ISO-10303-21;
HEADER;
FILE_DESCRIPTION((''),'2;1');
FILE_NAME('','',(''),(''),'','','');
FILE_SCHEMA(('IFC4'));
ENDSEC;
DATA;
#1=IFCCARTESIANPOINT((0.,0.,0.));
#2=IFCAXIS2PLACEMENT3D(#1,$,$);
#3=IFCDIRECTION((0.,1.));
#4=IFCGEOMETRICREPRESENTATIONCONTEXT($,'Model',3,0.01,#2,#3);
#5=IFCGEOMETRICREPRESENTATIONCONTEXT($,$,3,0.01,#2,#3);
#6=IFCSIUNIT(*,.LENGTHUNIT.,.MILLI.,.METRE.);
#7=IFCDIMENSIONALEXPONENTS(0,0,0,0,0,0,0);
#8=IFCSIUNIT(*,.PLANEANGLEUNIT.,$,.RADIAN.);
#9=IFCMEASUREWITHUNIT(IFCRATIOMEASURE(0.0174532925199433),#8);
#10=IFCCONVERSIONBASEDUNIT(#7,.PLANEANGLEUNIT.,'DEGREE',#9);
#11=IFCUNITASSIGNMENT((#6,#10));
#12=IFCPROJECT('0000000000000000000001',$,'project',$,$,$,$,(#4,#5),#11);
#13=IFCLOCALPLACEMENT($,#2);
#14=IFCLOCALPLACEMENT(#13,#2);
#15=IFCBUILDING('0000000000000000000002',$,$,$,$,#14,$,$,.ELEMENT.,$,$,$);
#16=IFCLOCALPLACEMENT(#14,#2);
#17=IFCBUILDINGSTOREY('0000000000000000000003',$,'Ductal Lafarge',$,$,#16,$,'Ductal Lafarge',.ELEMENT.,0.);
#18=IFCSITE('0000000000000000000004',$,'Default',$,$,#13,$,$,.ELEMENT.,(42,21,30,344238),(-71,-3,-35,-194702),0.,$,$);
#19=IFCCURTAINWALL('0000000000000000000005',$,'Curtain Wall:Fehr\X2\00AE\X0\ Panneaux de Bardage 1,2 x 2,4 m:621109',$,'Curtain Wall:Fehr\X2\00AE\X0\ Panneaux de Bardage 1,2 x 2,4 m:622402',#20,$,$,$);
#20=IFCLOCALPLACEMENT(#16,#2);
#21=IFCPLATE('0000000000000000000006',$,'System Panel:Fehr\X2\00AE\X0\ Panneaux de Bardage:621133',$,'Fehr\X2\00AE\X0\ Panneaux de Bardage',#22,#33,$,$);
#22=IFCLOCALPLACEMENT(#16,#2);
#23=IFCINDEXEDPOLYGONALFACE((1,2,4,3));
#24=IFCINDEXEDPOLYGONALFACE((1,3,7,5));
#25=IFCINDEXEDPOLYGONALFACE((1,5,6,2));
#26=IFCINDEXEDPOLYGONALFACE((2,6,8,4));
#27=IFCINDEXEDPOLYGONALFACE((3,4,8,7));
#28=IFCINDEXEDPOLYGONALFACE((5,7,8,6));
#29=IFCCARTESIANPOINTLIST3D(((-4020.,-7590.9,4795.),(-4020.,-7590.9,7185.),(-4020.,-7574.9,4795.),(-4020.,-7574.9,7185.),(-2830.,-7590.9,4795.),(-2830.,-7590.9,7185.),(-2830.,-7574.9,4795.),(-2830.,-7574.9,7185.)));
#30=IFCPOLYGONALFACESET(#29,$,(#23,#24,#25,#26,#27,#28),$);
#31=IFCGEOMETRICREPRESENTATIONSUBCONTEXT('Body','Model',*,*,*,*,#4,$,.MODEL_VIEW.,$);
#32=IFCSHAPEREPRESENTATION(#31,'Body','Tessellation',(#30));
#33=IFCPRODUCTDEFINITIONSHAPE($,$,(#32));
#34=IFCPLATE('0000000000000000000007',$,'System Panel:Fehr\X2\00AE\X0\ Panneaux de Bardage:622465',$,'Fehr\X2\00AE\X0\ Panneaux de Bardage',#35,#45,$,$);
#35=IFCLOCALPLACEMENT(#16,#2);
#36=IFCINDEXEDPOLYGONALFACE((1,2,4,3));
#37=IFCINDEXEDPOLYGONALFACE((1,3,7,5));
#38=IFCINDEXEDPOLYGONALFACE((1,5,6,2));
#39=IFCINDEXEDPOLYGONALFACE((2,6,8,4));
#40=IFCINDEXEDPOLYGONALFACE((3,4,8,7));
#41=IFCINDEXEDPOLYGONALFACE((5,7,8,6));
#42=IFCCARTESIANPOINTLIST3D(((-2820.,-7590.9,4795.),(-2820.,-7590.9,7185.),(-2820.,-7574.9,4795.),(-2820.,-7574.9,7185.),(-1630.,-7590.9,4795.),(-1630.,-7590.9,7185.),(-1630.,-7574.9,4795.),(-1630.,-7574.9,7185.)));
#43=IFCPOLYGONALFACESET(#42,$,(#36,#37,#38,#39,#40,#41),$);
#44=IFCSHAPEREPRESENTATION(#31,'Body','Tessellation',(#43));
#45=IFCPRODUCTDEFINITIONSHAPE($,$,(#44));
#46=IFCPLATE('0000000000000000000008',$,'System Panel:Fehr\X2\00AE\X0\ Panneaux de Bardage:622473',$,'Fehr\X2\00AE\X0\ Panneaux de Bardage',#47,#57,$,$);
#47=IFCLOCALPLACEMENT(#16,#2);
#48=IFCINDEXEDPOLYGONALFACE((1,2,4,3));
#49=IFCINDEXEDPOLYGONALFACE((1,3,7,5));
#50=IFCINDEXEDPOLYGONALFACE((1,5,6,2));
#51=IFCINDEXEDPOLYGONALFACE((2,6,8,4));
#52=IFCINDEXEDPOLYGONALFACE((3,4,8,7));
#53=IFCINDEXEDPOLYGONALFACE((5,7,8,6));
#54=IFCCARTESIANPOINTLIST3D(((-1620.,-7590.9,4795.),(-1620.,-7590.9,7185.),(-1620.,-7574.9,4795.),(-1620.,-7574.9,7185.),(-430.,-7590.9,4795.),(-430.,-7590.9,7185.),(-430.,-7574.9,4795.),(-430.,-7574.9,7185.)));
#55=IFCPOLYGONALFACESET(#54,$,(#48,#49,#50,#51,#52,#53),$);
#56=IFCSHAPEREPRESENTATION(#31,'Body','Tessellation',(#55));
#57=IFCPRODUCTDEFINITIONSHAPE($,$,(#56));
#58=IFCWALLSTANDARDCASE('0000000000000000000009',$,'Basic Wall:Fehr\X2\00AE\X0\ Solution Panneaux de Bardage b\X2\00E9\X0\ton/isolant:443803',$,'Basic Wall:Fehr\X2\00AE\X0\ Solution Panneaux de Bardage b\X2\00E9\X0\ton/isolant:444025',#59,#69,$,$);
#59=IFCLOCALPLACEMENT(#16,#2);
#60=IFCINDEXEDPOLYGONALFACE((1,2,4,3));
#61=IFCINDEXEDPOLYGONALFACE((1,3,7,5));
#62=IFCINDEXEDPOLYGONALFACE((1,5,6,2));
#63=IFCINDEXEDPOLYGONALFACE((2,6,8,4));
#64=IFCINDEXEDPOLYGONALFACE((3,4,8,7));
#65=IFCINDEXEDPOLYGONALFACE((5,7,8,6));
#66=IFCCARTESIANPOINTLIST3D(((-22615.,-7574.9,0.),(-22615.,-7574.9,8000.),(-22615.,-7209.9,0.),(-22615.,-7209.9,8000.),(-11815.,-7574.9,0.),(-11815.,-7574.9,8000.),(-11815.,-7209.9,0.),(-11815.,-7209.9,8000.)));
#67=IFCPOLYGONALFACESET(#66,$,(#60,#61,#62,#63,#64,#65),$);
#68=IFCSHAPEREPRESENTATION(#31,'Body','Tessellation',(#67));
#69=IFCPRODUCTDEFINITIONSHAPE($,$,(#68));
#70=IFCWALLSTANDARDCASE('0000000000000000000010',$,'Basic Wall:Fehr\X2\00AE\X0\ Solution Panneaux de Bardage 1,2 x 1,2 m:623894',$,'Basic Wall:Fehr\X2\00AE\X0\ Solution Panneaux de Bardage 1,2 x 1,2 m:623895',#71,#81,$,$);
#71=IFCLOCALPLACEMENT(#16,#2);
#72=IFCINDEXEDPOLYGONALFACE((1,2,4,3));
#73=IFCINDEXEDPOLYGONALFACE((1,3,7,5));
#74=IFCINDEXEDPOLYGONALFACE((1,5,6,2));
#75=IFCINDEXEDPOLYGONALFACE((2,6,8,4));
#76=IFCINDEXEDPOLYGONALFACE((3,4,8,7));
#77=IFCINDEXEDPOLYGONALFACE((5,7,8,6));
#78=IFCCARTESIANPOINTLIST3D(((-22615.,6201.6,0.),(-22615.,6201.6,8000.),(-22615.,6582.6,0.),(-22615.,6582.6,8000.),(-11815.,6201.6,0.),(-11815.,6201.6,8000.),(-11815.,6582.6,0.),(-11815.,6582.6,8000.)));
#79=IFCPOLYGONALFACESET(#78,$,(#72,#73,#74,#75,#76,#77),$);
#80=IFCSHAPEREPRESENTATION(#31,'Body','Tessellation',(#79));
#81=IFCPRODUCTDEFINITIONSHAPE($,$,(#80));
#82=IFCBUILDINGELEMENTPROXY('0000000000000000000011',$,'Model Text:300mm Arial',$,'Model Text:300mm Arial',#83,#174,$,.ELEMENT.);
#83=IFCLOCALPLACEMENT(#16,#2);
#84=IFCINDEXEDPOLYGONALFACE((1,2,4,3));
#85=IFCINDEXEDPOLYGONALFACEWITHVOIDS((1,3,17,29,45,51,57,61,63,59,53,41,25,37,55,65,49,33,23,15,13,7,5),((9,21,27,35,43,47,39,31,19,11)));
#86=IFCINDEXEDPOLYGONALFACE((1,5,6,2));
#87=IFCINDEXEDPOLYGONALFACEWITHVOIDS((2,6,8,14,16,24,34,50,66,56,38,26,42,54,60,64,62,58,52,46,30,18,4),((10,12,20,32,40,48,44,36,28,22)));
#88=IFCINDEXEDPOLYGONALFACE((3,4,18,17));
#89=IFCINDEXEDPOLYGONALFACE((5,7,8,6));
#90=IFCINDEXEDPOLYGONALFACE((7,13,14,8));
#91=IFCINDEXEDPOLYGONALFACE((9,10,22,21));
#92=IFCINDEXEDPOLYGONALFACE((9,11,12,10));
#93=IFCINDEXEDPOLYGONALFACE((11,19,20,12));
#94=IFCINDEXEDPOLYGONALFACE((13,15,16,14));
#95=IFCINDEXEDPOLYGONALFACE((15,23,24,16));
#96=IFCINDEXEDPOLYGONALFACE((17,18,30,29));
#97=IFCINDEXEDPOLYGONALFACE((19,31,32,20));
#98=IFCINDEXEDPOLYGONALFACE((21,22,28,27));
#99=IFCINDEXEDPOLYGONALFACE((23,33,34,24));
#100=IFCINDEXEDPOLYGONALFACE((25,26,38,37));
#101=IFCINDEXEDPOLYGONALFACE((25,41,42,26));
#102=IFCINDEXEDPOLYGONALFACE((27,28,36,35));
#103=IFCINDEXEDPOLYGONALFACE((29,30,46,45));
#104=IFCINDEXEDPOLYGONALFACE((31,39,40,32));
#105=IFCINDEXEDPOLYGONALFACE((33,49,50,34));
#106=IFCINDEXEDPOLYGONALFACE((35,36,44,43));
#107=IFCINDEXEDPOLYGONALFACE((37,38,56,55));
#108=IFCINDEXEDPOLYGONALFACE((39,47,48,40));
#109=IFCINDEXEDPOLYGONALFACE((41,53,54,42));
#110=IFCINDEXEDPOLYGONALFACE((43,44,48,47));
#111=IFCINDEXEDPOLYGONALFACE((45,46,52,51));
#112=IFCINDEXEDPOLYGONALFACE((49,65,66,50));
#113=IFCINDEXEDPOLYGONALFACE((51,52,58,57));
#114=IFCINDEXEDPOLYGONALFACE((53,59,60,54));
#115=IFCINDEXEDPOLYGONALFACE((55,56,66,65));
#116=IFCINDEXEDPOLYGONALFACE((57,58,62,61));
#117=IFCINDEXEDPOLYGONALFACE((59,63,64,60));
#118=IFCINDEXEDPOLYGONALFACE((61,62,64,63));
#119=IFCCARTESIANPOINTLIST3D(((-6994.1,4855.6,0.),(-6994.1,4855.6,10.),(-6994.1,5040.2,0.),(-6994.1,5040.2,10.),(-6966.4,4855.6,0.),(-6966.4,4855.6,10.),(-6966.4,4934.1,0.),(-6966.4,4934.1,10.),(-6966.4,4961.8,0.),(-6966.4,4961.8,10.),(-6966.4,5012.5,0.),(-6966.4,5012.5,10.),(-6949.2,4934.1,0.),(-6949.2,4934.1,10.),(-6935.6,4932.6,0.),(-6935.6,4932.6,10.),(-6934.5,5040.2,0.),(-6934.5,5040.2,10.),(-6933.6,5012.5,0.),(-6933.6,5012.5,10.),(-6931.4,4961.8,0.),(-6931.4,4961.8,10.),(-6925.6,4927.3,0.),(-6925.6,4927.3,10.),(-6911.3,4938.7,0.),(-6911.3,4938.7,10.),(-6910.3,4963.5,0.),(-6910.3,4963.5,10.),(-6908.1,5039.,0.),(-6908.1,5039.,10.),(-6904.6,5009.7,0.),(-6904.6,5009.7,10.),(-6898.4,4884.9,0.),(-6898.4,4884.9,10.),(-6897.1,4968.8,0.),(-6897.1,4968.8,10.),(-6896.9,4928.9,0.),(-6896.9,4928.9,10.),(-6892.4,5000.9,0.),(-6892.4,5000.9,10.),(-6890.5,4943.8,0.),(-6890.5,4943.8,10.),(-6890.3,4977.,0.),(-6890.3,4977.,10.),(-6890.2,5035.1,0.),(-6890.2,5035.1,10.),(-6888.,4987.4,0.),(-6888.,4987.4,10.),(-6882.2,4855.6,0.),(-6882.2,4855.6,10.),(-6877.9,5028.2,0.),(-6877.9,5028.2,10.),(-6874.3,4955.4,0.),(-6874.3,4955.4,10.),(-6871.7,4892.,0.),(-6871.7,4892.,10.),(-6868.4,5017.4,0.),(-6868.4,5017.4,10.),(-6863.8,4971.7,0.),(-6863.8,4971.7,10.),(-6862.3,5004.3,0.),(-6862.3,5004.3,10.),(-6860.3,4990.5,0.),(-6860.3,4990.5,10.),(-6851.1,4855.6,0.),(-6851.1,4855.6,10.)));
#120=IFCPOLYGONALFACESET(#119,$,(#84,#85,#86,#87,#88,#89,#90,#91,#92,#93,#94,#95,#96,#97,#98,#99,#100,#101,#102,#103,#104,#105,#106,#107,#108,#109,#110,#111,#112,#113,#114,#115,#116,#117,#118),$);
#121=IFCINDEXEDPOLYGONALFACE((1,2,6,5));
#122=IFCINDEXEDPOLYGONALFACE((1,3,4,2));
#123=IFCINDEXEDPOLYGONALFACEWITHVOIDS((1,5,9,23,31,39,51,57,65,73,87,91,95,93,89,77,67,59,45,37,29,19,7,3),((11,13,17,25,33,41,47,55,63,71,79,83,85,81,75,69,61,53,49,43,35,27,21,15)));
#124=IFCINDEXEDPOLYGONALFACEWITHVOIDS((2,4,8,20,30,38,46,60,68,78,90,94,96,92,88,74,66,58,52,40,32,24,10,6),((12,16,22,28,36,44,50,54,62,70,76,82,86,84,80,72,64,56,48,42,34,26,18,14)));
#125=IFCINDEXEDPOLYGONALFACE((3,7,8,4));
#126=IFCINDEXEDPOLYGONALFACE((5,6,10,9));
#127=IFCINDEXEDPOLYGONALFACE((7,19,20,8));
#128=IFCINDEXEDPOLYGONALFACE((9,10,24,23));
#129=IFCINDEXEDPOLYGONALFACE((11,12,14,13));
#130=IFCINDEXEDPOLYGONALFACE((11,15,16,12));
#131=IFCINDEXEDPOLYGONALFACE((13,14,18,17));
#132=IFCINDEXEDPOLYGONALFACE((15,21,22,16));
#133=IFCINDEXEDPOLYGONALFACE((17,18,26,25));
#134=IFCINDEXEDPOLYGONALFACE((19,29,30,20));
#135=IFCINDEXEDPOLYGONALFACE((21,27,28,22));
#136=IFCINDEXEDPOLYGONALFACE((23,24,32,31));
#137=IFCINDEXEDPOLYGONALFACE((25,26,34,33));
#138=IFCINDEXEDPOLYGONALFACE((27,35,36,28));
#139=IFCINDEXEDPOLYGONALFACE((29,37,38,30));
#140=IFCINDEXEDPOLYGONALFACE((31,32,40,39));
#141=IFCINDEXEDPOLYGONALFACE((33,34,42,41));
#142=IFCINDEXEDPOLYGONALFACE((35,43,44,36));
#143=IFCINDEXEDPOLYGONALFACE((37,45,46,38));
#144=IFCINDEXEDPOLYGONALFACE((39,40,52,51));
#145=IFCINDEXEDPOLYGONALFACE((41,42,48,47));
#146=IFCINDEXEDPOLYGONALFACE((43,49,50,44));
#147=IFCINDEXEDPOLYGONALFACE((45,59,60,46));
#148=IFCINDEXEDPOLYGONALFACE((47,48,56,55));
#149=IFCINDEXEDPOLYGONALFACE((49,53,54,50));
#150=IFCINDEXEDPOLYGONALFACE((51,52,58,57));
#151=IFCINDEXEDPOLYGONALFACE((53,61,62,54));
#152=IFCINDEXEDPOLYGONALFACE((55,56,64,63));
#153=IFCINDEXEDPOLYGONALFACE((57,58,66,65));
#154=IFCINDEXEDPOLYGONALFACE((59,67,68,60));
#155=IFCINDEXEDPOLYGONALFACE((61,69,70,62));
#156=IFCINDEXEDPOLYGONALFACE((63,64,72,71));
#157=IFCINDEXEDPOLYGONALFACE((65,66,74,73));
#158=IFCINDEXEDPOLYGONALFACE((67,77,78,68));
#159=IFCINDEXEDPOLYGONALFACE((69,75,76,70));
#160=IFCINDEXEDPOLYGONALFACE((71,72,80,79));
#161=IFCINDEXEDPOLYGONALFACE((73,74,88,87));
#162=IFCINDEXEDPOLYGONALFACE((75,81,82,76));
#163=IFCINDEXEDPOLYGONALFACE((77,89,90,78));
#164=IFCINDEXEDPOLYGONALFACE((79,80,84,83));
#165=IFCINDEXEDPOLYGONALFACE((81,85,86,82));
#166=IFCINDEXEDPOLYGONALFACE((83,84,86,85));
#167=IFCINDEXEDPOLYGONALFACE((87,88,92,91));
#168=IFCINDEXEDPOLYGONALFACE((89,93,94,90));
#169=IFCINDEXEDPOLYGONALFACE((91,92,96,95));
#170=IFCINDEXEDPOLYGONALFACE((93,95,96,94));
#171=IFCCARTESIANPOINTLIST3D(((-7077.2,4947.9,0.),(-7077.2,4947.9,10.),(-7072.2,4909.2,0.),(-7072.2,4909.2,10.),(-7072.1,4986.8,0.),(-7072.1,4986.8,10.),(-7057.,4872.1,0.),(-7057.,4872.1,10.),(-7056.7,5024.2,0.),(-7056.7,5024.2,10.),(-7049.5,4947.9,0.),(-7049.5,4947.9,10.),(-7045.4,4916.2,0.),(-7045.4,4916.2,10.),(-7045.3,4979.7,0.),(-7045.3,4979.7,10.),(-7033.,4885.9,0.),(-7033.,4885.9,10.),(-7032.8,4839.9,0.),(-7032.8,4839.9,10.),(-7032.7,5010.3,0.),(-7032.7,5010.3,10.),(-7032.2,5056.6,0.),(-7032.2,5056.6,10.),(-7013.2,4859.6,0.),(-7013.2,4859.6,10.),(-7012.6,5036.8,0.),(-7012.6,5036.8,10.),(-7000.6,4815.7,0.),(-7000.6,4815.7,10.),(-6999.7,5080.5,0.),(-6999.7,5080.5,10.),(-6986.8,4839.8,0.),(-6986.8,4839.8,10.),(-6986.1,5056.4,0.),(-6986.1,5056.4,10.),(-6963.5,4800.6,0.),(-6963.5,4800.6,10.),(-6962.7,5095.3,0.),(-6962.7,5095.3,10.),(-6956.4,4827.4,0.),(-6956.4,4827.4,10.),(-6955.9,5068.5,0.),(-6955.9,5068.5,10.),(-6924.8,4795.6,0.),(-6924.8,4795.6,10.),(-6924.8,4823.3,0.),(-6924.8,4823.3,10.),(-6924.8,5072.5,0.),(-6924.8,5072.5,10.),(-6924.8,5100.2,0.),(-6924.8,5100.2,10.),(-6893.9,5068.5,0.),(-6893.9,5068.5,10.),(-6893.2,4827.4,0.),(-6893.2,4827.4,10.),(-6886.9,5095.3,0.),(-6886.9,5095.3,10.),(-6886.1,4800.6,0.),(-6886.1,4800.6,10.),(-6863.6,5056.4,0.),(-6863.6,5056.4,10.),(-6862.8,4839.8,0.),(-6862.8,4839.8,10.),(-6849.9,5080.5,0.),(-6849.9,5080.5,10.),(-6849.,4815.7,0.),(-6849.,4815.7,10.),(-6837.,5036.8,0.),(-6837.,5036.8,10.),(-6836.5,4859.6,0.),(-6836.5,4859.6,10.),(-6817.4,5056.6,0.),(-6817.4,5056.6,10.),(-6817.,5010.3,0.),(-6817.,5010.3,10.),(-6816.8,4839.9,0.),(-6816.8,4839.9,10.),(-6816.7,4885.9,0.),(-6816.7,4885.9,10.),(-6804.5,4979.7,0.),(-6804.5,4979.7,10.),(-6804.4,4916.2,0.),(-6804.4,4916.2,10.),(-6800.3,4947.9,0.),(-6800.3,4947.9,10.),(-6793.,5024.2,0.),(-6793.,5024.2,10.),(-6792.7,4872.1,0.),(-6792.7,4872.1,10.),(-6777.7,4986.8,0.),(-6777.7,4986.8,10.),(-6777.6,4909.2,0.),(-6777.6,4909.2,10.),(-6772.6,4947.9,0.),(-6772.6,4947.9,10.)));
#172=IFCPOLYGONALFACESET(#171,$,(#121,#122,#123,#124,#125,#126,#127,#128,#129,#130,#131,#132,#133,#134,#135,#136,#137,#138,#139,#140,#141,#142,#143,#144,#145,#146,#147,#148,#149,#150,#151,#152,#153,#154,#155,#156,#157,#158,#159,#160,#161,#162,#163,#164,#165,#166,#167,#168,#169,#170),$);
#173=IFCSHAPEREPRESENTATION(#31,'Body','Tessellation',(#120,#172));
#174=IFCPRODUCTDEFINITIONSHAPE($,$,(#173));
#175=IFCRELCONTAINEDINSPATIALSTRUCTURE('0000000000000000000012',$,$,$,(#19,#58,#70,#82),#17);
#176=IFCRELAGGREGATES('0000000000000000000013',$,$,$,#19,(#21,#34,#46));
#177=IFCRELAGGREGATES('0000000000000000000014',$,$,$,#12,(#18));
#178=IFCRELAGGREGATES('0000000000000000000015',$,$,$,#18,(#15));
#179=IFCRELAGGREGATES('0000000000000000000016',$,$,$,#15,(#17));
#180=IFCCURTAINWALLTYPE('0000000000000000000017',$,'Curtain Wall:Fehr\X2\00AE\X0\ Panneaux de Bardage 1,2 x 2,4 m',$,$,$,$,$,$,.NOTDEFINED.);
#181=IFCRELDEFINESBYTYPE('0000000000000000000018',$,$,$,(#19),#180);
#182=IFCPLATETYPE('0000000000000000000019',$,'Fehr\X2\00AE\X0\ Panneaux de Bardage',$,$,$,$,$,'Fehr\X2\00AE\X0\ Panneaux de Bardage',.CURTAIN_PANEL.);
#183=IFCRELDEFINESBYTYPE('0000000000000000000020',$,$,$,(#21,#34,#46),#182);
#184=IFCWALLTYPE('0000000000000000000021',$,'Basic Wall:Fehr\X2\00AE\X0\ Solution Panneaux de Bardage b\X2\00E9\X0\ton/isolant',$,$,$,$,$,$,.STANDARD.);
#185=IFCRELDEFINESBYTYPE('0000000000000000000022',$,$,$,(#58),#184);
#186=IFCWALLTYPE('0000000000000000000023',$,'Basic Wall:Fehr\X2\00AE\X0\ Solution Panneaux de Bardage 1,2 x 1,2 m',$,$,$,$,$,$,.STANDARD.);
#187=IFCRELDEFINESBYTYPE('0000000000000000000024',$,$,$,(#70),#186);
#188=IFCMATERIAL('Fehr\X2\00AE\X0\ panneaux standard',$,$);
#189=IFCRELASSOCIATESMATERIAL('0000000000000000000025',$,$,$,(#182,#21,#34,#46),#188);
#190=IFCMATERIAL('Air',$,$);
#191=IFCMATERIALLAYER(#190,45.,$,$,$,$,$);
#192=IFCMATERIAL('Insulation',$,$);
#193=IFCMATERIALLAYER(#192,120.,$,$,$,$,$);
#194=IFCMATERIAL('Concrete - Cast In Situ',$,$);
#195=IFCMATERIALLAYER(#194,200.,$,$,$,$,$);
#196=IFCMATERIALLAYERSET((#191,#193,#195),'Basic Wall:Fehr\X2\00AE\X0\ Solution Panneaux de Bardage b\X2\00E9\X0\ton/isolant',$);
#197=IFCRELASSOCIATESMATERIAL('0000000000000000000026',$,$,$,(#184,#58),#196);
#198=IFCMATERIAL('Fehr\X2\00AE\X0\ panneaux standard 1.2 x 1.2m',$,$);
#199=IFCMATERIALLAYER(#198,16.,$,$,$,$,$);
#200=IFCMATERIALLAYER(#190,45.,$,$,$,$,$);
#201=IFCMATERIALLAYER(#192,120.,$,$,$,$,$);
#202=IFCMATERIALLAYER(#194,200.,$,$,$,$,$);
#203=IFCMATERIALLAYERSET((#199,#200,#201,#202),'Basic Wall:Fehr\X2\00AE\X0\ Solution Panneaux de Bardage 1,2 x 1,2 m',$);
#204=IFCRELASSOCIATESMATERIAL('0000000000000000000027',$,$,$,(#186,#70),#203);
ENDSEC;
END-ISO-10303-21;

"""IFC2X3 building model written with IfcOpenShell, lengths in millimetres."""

from ifc_helpers import new_model, entity, si_unit, converted_unit, direction, frame, frame_2d, origin, origin_2d_with_axis, place, context, subcontext, project, spatial, polyline, rectangle, outline, extrude, source, transform, mapped, material, layer, layer_set, layer_usage, type_object, type_shapes, element, aggregate, save


model = new_model("IFC2X3")

# Units and contexts
model_context = context("Model", 3, precision=0.01, world=origin(), true_north=direction((0.0, 1.0)))
context_of_model = context(None, 3, precision=0.01, world=origin(), true_north=direction((0.0, 1.0)))
body_context = subcontext(model_context, "Body", "Model", "MODEL_VIEW")
ifc_project = project(units=[si_unit("LENGTHUNIT", "METRE", prefix="MILLI"), converted_unit("PLANEANGLEUNIT", "DEGREE", entity("IfcRatioMeasure", 0.0174532925199433), si_unit("PLANEANGLEUNIT", "RADIAN"), dimensions=[0, 0, 0, 0, 0, 0, 0])], contexts=[model_context, context_of_model])

# Site, building, storey
site_placement = place(None, origin())
site = spatial("IfcSite", under=ifc_project, at=site_placement, Name="Default", CompositionType="ELEMENT", RefLatitude=(42, 21, 30, 344238), RefLongitude=(-71, -3, -35, -194702), RefElevation=0.0)
building_placement = place(site_placement, origin())
building = spatial("IfcBuilding", under=site, at=building_placement, CompositionType="ELEMENT")
storey_placement = place(building_placement, origin())
storey = spatial("IfcBuildingStorey", under=building, at=storey_placement, Name="Ductal Lafarge", LongName="Ductal Lafarge", CompositionType="ELEMENT", Elevation=0.0)

# Curtain wall
ifc_material_1 = material(Name="Fehr® panneaux standard")
curtain_wall_type_1 = type_object("IfcCurtainWallType", Name="Curtain Wall:Fehr® Panneaux de Bardage 1,2 x 2,4 m", PredefinedType="NOTDEFINED")
curtain_wall_1_placement = place(storey_placement, origin())
curtain_wall_1 = element("IfcCurtainWall", 1, at=curtain_wall_1_placement, inside=storey, type_object=curtain_wall_type_1, Name="Curtain Wall:Fehr® Panneaux de Bardage 1,2 x 2,4 m:621109", ObjectType="Curtain Wall:Fehr® Panneaux de Bardage 1,2 x 2,4 m:622402")

# Plates
plate_type_1 = type_object("IfcPlateType", Name="Fehr® Panneaux de Bardage", ElementType="Fehr® Panneaux de Bardage", PredefinedType="CURTAIN_PANEL", material=ifc_material_1)
shared_shape_1 = source(origin(), body_context, "Body", "SweptSolid", [
    extrude(rectangle(XDim=16.0, YDim=1190.0, at=origin_2d_with_axis()), frame((0.0, 0.0, 0.0), z_axis=(0.0, 0.0, 1.0), x_axis=(0.0, 1.0, 0.0)), (0.0, 0.0, 1.0), 2390.0),
])
type_shapes(plate_type_1, [shared_shape_1])
plate_1_placement = place(curtain_wall_1_placement, frame((-3425.0, -7582.9, 4795.0)))
plate_1 = element("IfcPlate", 2, at=plate_1_placement, type_object=plate_type_1, material=ifc_material_1, Name="System Panel:Fehr® Panneaux de Bardage:621133", ObjectType="Fehr® Panneaux de Bardage", context=body_context, shape_type="MappedRepresentation", body=[
    mapped(shared_shape_1, transform((0.0, 0.0, 0.0), scale=1.0)),
])
plate_2_placement = place(curtain_wall_1_placement, frame((-2225.0, -7582.9, 4795.0)))
plate_2 = element("IfcPlate", 3, at=plate_2_placement, type_object=plate_type_1, material=ifc_material_1, Name="System Panel:Fehr® Panneaux de Bardage:622465", ObjectType="Fehr® Panneaux de Bardage", context=body_context, shape_type="MappedRepresentation", body=[
    mapped(shared_shape_1, transform((0.0, 0.0, 0.0), scale=1.0)),
])
plate_3_placement = place(curtain_wall_1_placement, frame((-1025.0, -7582.9, 4795.0)))
plate_3 = element("IfcPlate", 4, at=plate_3_placement, type_object=plate_type_1, material=ifc_material_1, Name="System Panel:Fehr® Panneaux de Bardage:622473", ObjectType="Fehr® Panneaux de Bardage", context=body_context, shape_type="MappedRepresentation", body=[
    mapped(shared_shape_1, transform((0.0, 0.0, 0.0), scale=1.0)),
])
aggregate(curtain_wall_1, [plate_1, plate_2, plate_3])

# Walls
ifc_material_2 = material(Name="Air")
ifc_layer_1 = layer(ifc_material_2, 45.0)
ifc_material_3 = material(Name="Insulation")
ifc_layer_2 = layer(ifc_material_3, 120.0)
ifc_material_4 = material(Name="Concrete - Cast In Situ")
ifc_layer_3 = layer(ifc_material_4, 200.0)
ifc_layer_set_1 = layer_set([ifc_layer_1, ifc_layer_2, ifc_layer_3], Name="Basic Wall:Fehr® Solution Panneaux de Bardage béton/isolant")
ifc_layer_usage_1 = layer_usage(ifc_layer_set_1, "AXIS2", "NEGATIVE", 182.5)
wall_type_1 = type_object("IfcWallType", Name="Basic Wall:Fehr® Solution Panneaux de Bardage béton/isolant", PredefinedType="STANDARD", material=ifc_layer_set_1)
wall_1_placement = place(storey_placement, frame((-11815.0, -7392.4, 0.0), z_axis=(0.0, 0.0, 1.0), x_axis=(-1.0, 0.0, 0.0)))
element("IfcWallStandardCase", 5, at=wall_1_placement, inside=storey, type_object=wall_type_1, material=ifc_layer_usage_1, Name="Basic Wall:Fehr® Solution Panneaux de Bardage béton/isolant:443803", ObjectType="Basic Wall:Fehr® Solution Panneaux de Bardage béton/isolant:444025", context=body_context, shape_type="SweptSolid", body=[
    extrude(rectangle(XDim=10800.0, YDim=365.0, at=frame_2d((5400.0, 0.0), x_axis=(-1.0, 0.0))), origin(), (0.0, 0.0, 1.0), 8000.0),
])
ifc_material_5 = material(Name="Fehr® panneaux standard 1.2 x 1.2m")
ifc_layer_4 = layer(ifc_material_5, 16.0)
ifc_layer_5 = layer(ifc_material_2, 45.0)
ifc_layer_6 = layer(ifc_material_3, 120.0)
ifc_layer_7 = layer(ifc_material_4, 200.0)
ifc_layer_set_2 = layer_set([ifc_layer_4, ifc_layer_5, ifc_layer_6, ifc_layer_7], Name="Basic Wall:Fehr® Solution Panneaux de Bardage 1,2 x 1,2 m")
ifc_layer_usage_2 = layer_usage(ifc_layer_set_2, "AXIS2", "NEGATIVE", 190.5)
wall_type_2 = type_object("IfcWallType", Name="Basic Wall:Fehr® Solution Panneaux de Bardage 1,2 x 1,2 m", PredefinedType="STANDARD", material=ifc_layer_set_2)
wall_2_placement = place(storey_placement, frame((-11815.0, 6392.1, 0.0), z_axis=(0.0, 0.0, 1.0), x_axis=(-1.0, 0.0, 0.0)))
element("IfcWallStandardCase", 6, at=wall_2_placement, inside=storey, type_object=wall_type_2, material=ifc_layer_usage_2, Name="Basic Wall:Fehr® Solution Panneaux de Bardage 1,2 x 1,2 m:623894", ObjectType="Basic Wall:Fehr® Solution Panneaux de Bardage 1,2 x 1,2 m:623895", context=body_context, shape_type="SweptSolid", body=[
    extrude(rectangle(XDim=10800.0, YDim=381.0, at=frame_2d((5400.0, 0.0), x_axis=(-1.0, 0.0))), origin(), (0.0, 0.0, 1.0), 8000.0),
])

# Building element proxy
proxy_1_placement = place(storey_placement, frame((-7077.2, 4795.6, 0.0)))
element("IfcBuildingElementProxy", 7, at=proxy_1_placement, inside=storey, Name="Model Text:300mm Arial", ObjectType="Model Text:300mm Arial", CompositionType="ELEMENT", context=body_context, shape_type="SweptSolid", body=[
    extrude(outline(polyline([(-86.6, -94.9), (-58.9, -94.9), (-58.9, -16.4), (-41.7, -16.4), (-28.0, -17.8), (-18.1, -23.2), (9.1, -65.6), (25.3, -94.9), (56.5, -94.9), (35.8, -58.4), (10.6, -21.6), (-3.8, -11.8), (17.0, -6.7), (33.3, 5.0), (43.8, 21.2), (47.3, 40.0), (45.2, 53.9), (39.1, 66.9), (29.6, 77.7), (17.3, 84.7), (-0.6, 88.5), (-26.9, 89.8), (-86.6, 89.8), (-86.6, -94.9)]), holes=[polyline([(-58.9, 11.3), (-58.9, 62.1), (-26.1, 62.1), (2.9, 59.2), (15.2, 50.4), (19.6, 37.0), (17.3, 26.5), (10.4, 18.3), (-2.7, 13.1), (-23.8, 11.3), (-58.9, 11.3)])]), frame((169.7, 154.9, 0.0)), (0.0, 0.0, 1.0), 10.0),
    extrude(outline(polyline([(-19.6, -150.9), (18.6, -150.9), (57.1, -141.0), (92.5, -121.5), (121.0, -92.5), (141.0, -57.4), (151.1, -19.4), (151.1, 19.5), (140.9, 58.3), (121.0, 93.4), (92.2, 121.5), (57.4, 141.2), (19.6, 151.2), (-19.4, 151.2), (-58.1, 141.0), (-93.2, 121.2), (-121.3, 92.3), (-141.0, 57.5), (-150.9, 19.8), (-150.9, -19.4), (-140.6, -58.5), (-120.5, -93.8), (-91.4, -121.7), (-56.6, -141.1), (-19.6, -150.9)]), holes=[polyline([(-16.1, -123.4), (-46.2, -115.4), (-74.7, -99.6), (-98.5, -76.7), (-114.9, -47.8), (-123.4, -15.8), (-123.5, 16.3), (-115.3, 47.1), (-99.2, 75.5), (-76.2, 99.1), (-47.5, 115.3), (-15.8, 123.7), (16.1, 123.7), (46.9, 115.6), (75.4, 99.4), (99.0, 76.3), (115.3, 47.7), (123.7, 16.0), (123.7, -15.9), (115.4, -46.9), (98.9, -75.6), (75.6, -99.3), (46.7, -115.3), (15.2, -123.4), (-16.1, -123.4)])]), frame((152.4, 152.5, 0.0), z_axis=(0.0, 0.0, 1.0), x_axis=(-0.991656, -0.128915, 0.0)), (0.0, 0.0, 1.0), 10.0),
])

save(model, "model.ifc")
